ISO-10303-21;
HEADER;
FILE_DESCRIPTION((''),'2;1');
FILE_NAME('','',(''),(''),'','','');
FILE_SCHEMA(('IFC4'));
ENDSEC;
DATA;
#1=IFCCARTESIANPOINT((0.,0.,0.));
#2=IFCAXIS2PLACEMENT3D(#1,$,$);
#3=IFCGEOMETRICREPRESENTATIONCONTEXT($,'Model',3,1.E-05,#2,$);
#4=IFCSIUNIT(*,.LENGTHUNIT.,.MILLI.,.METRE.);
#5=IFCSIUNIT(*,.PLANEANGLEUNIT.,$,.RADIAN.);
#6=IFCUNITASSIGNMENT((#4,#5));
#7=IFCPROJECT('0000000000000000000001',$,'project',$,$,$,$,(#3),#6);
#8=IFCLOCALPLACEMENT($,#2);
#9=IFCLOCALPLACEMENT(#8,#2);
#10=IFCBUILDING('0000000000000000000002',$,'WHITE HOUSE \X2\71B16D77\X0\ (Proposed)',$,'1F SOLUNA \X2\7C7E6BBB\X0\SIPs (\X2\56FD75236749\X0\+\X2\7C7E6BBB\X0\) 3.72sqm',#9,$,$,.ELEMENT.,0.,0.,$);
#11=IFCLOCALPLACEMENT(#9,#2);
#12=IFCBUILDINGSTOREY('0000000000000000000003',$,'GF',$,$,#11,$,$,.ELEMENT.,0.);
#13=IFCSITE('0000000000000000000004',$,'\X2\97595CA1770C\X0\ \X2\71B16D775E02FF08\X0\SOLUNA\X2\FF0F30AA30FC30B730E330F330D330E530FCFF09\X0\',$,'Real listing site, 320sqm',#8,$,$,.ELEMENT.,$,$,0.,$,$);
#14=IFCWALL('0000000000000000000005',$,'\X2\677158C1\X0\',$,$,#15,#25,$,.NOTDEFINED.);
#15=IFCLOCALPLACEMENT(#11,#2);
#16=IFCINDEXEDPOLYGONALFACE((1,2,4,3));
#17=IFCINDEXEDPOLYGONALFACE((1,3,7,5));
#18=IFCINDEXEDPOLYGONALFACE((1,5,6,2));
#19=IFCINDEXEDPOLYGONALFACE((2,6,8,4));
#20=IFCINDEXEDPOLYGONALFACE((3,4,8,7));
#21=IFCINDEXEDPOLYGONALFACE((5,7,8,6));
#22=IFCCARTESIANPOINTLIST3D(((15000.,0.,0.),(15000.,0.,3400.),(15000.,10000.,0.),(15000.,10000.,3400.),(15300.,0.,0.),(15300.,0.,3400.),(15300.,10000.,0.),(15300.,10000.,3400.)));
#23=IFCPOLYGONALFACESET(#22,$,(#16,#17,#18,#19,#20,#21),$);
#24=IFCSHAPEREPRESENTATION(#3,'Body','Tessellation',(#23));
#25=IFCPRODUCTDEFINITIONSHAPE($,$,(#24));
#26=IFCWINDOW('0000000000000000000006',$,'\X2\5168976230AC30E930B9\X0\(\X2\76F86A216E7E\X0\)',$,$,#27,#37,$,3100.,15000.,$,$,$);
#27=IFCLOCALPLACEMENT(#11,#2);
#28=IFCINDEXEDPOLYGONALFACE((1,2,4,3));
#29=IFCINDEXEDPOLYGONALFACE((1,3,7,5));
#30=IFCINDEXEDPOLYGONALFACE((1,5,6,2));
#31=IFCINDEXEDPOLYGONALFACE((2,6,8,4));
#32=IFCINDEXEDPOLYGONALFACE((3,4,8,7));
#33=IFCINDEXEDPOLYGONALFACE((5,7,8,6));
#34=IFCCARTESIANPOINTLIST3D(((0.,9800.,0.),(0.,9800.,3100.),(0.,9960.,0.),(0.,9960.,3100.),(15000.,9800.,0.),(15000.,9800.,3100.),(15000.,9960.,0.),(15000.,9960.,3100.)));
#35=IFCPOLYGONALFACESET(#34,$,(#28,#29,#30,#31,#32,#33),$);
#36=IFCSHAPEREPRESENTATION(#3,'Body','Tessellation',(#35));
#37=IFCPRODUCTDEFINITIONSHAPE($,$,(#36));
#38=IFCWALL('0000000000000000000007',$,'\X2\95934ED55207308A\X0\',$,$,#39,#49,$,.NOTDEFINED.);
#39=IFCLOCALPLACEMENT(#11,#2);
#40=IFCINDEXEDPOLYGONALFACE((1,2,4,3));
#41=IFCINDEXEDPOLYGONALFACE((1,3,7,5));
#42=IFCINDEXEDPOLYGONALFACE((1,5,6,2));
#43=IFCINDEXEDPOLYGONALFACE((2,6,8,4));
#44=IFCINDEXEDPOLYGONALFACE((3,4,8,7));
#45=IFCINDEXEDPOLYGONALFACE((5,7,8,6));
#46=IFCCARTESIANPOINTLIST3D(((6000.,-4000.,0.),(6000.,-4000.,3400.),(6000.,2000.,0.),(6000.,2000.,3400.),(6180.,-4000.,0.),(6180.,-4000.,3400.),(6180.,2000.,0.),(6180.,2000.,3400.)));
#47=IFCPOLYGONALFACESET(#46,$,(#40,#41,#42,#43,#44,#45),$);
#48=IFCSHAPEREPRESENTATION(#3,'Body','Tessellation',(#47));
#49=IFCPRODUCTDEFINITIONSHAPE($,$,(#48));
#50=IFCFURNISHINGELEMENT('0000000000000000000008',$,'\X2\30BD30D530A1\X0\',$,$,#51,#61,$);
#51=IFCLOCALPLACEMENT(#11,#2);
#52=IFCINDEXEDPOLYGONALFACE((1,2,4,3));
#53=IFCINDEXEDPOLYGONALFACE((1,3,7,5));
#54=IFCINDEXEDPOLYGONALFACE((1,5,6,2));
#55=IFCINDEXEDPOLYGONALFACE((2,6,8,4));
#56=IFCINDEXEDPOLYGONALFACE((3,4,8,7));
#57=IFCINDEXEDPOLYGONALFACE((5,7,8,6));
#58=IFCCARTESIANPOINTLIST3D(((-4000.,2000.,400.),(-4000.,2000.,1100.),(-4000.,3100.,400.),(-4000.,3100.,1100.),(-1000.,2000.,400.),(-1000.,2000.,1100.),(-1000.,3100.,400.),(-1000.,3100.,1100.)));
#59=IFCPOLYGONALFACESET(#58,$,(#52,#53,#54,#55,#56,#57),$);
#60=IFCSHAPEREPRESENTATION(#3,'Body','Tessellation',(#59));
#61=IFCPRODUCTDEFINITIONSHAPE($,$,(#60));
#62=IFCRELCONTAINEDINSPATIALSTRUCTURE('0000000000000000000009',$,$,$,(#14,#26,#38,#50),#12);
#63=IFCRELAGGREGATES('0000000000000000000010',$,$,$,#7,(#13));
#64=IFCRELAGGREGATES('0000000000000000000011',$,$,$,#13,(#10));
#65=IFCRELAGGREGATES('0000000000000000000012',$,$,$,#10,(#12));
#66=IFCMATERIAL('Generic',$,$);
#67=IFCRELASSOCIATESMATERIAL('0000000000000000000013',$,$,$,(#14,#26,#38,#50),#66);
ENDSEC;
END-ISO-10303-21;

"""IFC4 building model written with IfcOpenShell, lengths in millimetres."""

from ifc_helpers import new_model, si_unit, frame, frame_2d, origin, place, context, project, spatial, rectangle, extrude, material, element, fill, save


model = new_model("IFC4")

# Units and contexts
model_context = context("Model", 3, precision=1e-05, world=origin())
ifc_project = project(units=[si_unit("LENGTHUNIT", "METRE", prefix="MILLI"), si_unit("PLANEANGLEUNIT", "RADIAN")], contexts=[model_context])

# Site, building, storey
site_placement = place(None, origin())
site = spatial("IfcSite", under=ifc_project, at=site_placement, Name="静岡県 熱海市（SOLUNA／オーシャンビュー）", ObjectType="Real listing site, 320sqm", CompositionType="ELEMENT", RefElevation=0.0)
building_placement = place(site_placement, origin())
building = spatial("IfcBuilding", under=site, at=building_placement, Name="WHITE HOUSE 熱海 (Proposed)", ObjectType="1F SOLUNA 籾殻SIPs (国産杉+籾殻) 3.72sqm", CompositionType="ELEMENT", ElevationOfRefHeight=0.0, ElevationOfTerrain=0.0)
storey_placement = place(building_placement, origin())
storey = spatial("IfcBuildingStorey", under=building, at=storey_placement, Name="GF", CompositionType="ELEMENT", Elevation=0.0)

# Shared definitions
ifc_material_1 = material(Name="Generic")

# Wall, opening, window
wall_1_placement = place(storey_placement, frame((7500.0, 0.0, 0.0)))
wall_1 = element("IfcWall", 1, at=wall_1_placement, inside=storey, material=ifc_material_1, Name="東壁", PredefinedType="NOTDEFINED", context=model_context, shape_type="SweptSolid", body=[
    extrude(rectangle(XDim=300.0, YDim=10000.0, at=frame_2d((150.0, 5000.0))), frame((7500.0, 0.0, 0.0)), (0.0, 0.0, 1.0), 3400.0),
])
opening_placement = place(storey_placement, frame((0.0, 4900.0, 0.0)))
opening = element("IfcOpeningElement", 2, at=opening_placement, cuts=wall_1, PredefinedType="NOTDEFINED", context=model_context, shape_type="SweptSolid", body=[
    extrude(rectangle(XDim=15000.0, YDim=160.0, at=frame_2d((7500.0, 80.0))), frame((0.0, 4900.0, 0.0)), (0.0, 0.0, 1.0), 3100.0),
])
window_placement = place(storey_placement, frame((0.0, 4900.0, 0.0)))
window = element("IfcWindow", 3, at=window_placement, inside=storey, material=ifc_material_1, Name="全面ガラス(相模湾)", OverallHeight=3100.0, OverallWidth=15000.0, context=model_context, shape_type="SweptSolid", body=[
    extrude(rectangle(XDim=15000.0, YDim=160.0, at=frame_2d((7500.0, 80.0))), frame((0.0, 4900.0, 0.0)), (0.0, 0.0, 1.0), 3100.0),
])
fill(opening, window)

# Wall
wall_2_placement = place(storey_placement, frame((3000.0, -2000.0, 0.0)))
element("IfcWall", 4, at=wall_2_placement, inside=storey, material=ifc_material_1, Name="間仕切り", PredefinedType="NOTDEFINED", context=model_context, shape_type="SweptSolid", body=[
    extrude(rectangle(XDim=180.0, YDim=6000.0, at=frame_2d((90.0, 3000.0))), frame((3000.0, -2000.0, 0.0)), (0.0, 0.0, 1.0), 3400.0),
])

# Furnishing element
furnishing_1_placement = place(storey_placement, frame((-2000.0, 1000.0, 200.0)))
element("IfcFurnishingElement", 5, at=furnishing_1_placement, inside=storey, material=ifc_material_1, Name="ソファ", context=model_context, shape_type="SweptSolid", body=[
    extrude(rectangle(XDim=3000.0, YDim=1100.0, at=frame_2d((1500.0, 550.0))), frame((-2000.0, 1000.0, 200.0)), (0.0, 0.0, 1.0), 700.0),
])

save(model, "model.ifc")
